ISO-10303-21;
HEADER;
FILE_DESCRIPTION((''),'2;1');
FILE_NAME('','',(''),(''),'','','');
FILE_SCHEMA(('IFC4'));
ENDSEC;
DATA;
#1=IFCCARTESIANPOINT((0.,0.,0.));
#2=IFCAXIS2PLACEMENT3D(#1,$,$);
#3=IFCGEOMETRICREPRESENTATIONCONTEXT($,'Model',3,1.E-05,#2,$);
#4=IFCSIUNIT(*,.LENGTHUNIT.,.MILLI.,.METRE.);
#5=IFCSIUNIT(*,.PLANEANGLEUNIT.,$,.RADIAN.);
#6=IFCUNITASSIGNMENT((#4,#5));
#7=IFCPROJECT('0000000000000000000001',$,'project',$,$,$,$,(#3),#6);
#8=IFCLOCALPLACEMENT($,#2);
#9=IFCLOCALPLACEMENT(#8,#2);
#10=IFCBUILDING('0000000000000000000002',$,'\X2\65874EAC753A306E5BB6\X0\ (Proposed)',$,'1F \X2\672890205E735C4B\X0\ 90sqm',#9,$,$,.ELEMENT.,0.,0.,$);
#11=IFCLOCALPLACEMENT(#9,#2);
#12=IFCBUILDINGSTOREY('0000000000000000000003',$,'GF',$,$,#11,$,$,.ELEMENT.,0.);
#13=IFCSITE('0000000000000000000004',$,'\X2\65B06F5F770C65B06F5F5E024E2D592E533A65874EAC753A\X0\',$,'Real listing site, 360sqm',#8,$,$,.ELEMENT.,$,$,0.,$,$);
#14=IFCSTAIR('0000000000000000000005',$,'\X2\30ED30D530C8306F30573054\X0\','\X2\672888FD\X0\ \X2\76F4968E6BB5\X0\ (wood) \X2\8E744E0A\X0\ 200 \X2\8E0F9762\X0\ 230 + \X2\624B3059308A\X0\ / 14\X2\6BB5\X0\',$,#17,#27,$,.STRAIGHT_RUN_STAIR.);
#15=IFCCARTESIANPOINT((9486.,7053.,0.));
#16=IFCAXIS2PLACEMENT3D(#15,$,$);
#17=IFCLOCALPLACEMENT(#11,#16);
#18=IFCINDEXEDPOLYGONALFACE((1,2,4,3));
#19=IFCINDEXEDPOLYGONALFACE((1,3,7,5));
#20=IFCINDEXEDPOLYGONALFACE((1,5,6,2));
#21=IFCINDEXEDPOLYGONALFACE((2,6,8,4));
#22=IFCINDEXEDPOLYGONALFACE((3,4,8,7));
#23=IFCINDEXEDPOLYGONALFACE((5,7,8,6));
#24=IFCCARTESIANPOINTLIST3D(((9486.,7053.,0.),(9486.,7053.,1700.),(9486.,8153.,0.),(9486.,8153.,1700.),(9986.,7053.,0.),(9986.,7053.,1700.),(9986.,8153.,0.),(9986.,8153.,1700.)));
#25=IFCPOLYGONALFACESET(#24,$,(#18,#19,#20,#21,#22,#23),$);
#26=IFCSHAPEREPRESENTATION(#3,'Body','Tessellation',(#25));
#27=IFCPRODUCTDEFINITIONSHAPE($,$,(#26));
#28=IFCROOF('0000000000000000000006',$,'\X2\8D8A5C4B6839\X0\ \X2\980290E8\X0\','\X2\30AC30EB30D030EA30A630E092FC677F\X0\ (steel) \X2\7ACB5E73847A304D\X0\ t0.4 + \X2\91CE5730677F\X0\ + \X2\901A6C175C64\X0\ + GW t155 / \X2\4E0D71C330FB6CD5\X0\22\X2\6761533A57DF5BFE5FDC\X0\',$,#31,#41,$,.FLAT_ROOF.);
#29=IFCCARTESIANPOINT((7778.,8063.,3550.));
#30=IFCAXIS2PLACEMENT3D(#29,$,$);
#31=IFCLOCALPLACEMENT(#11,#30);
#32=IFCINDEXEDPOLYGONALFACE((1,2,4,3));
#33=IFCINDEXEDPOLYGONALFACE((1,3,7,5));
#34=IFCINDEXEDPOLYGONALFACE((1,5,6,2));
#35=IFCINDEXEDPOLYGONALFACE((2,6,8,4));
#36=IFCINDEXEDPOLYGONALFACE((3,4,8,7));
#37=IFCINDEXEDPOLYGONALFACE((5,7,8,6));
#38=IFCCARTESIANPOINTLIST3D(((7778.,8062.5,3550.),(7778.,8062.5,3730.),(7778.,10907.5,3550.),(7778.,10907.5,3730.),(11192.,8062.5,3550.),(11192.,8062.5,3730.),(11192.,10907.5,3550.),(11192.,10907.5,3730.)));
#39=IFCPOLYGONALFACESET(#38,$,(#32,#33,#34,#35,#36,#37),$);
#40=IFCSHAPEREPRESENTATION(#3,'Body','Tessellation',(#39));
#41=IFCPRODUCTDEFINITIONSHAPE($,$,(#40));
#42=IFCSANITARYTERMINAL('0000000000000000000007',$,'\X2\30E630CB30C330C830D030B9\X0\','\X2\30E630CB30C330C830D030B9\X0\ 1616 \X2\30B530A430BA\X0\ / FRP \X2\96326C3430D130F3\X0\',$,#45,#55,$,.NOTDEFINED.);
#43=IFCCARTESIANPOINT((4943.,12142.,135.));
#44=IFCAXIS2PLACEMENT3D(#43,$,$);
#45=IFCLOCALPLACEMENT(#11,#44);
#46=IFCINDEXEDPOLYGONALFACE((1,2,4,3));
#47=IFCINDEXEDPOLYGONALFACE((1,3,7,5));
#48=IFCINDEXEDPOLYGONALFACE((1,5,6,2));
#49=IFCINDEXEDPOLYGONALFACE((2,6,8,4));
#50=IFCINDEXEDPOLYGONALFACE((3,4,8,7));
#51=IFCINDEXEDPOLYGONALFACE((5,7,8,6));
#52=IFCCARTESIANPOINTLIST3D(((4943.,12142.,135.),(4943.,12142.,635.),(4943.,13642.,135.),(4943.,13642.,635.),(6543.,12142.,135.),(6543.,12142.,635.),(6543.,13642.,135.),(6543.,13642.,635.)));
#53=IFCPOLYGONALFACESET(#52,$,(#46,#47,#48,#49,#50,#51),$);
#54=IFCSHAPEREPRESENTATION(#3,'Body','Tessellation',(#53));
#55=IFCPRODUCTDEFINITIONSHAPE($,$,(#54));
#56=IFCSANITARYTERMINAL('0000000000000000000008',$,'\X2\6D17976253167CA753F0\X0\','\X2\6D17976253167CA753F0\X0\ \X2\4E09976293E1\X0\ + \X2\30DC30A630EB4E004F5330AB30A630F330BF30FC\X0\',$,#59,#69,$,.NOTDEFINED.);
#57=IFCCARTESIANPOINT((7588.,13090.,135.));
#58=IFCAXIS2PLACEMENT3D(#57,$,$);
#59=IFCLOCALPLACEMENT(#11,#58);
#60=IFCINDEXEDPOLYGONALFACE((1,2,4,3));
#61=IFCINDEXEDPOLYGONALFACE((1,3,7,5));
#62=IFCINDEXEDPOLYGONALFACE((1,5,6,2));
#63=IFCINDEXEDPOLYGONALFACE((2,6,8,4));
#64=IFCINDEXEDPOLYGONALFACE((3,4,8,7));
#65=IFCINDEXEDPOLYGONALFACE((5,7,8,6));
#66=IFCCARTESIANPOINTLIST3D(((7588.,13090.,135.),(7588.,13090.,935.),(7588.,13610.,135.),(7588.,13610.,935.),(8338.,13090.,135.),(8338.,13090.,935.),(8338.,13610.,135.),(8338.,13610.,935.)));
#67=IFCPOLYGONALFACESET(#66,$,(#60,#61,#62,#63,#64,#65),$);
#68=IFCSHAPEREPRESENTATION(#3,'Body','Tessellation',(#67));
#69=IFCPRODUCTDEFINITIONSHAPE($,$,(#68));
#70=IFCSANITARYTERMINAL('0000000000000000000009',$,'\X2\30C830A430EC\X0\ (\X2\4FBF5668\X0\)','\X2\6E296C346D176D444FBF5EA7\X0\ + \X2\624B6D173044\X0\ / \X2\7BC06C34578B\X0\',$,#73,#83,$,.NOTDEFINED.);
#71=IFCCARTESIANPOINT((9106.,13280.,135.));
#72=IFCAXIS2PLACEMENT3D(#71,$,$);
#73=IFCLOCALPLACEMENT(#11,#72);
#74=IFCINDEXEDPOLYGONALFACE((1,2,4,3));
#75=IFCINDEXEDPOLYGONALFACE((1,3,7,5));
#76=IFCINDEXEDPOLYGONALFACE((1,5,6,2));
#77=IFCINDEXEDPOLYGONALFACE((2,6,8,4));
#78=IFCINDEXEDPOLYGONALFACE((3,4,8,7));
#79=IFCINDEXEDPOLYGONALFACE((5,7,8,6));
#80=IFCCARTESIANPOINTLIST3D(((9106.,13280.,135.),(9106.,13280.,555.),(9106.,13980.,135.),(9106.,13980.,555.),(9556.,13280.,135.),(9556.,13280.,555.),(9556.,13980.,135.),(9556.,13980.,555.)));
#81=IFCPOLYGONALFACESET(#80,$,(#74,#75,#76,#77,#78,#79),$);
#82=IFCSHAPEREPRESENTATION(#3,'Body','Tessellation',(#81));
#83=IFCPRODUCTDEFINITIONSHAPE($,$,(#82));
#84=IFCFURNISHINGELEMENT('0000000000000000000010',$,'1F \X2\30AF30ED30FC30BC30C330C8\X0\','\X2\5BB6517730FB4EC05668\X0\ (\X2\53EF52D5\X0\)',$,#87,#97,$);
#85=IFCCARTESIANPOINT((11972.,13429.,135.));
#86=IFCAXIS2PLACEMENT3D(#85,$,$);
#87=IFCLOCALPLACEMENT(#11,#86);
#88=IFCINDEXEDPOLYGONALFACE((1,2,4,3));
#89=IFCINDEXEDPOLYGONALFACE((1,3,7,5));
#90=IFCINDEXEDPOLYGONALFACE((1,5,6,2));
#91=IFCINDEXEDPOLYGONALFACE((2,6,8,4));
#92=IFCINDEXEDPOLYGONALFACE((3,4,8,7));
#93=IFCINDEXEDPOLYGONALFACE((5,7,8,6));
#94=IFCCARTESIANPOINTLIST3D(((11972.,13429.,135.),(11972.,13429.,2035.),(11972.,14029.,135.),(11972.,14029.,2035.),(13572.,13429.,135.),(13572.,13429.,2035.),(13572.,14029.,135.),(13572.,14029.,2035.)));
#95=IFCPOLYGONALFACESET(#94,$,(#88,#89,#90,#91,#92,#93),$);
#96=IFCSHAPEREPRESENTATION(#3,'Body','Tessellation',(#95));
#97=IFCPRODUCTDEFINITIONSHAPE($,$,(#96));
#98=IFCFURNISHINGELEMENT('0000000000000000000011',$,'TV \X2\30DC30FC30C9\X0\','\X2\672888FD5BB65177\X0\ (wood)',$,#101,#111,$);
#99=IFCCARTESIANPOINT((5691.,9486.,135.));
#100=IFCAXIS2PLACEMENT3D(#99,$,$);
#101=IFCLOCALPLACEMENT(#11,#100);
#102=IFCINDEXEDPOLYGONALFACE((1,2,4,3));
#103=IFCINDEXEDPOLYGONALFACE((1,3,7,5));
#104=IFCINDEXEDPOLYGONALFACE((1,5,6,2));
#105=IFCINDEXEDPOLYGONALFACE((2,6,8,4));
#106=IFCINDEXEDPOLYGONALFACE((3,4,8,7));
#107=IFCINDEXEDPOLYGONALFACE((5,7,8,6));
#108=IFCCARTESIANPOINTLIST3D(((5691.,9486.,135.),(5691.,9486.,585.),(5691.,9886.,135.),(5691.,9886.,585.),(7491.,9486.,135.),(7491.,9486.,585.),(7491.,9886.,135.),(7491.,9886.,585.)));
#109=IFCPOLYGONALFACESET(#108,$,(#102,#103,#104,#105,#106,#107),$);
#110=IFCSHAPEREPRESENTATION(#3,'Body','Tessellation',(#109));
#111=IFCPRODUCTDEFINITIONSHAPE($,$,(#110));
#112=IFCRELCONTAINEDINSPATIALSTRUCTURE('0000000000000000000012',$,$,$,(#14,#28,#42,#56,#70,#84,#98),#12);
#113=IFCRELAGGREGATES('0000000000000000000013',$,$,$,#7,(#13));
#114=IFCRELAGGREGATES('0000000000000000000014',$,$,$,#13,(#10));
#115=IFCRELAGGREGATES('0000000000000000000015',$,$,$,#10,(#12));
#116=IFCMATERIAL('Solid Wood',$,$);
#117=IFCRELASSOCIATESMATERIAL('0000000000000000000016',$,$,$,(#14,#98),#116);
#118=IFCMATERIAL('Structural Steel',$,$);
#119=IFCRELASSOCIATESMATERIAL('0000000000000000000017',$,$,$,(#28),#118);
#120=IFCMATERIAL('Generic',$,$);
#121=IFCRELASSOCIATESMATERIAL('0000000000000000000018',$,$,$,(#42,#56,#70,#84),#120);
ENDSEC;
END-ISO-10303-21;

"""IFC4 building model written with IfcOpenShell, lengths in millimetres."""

from ifc_helpers import new_model, si_unit, frame, frame_2d, origin, place, context, project, spatial, rectangle, extrude, material, element, save


model = new_model("IFC4")

# Units and contexts
model_context = context("Model", 3, precision=1e-05, world=origin())
ifc_project = project(units=[si_unit("LENGTHUNIT", "METRE", prefix="MILLI"), si_unit("PLANEANGLEUNIT", "RADIAN")], contexts=[model_context])

# Site, building, storey
site_placement = place(None, origin())
site = spatial("IfcSite", under=ifc_project, at=site_placement, Name="新潟県新潟市中央区文京町", ObjectType="Real listing site, 360sqm", CompositionType="ELEMENT", RefElevation=0.0)
building_placement = place(site_placement, origin())
building = spatial("IfcBuilding", under=site, at=building_placement, Name="文京町の家 (Proposed)", ObjectType="1F 木造平屋 90sqm", CompositionType="ELEMENT", ElevationOfRefHeight=0.0, ElevationOfTerrain=0.0)
storey_placement = place(building_placement, origin())
storey = spatial("IfcBuildingStorey", under=building, at=storey_placement, Name="GF", CompositionType="ELEMENT", Elevation=0.0)

# Shared definitions
ifc_material_1 = material(Name="Solid Wood")

# Stair
stair_placement = place(storey_placement, frame((9486.0, 7053.0, 0.0)))
element("IfcStair", 1, at=stair_placement, inside=storey, material=ifc_material_1, Name="ロフトはしご", Description="木製 直階段 (wood) 蹴上 200 踏面 230 + 手すり / 14段", PredefinedType="STRAIGHT_RUN_STAIR", context=model_context, shape_type="SweptSolid", body=[
    extrude(rectangle(XDim=500.0, YDim=1100.0, at=frame_2d((250.0, 550.0))), frame((9486.0, 7053.0, 0.0)), (0.0, 0.0, 1.0), 1700.0),
])

# Roof
ifc_material_2 = material(Name="Structural Steel")
roof_placement = place(storey_placement, frame((7778.0, 8063.0, 3550.0)))
element("IfcRoof", 2, at=roof_placement, inside=storey, material=ifc_material_2, Name="越屋根 頂部", Description="ガルバリウム鋼板 (steel) 立平葺き t0.4 + 野地板 + 通気層 + GW t155 / 不燃・法22条区域対応", PredefinedType="FLAT_ROOF", context=model_context, shape_type="SweptSolid", body=[
    extrude(rectangle(XDim=3414.0, YDim=2845.0, at=frame_2d((1707.0, 1422.0))), frame((7778.0, 8063.0, 3550.0)), (0.0, 0.0, 1.0), 180.0),
])

# Sanitary terminals
ifc_material_3 = material(Name="Generic")
sanitary_terminal_1_placement = place(storey_placement, frame((4943.0, 12142.0, 135.0)))
element("IfcSanitaryTerminal", 3, at=sanitary_terminal_1_placement, inside=storey, material=ifc_material_3, Name="ユニットバス", Description="ユニットバス 1616 サイズ / FRP 防水パン", PredefinedType="NOTDEFINED", context=model_context, shape_type="SweptSolid", body=[
    extrude(rectangle(XDim=1600.0, YDim=1500.0, at=frame_2d((800.0, 750.0))), frame((4943.0, 12142.0, 135.0)), (0.0, 0.0, 1.0), 500.0),
])
sanitary_terminal_2_placement = place(storey_placement, frame((7588.0, 13090.0, 135.0)))
element("IfcSanitaryTerminal", 4, at=sanitary_terminal_2_placement, inside=storey, material=ifc_material_3, Name="洗面化粧台", Description="洗面化粧台 三面鏡 + ボウル一体カウンター", PredefinedType="NOTDEFINED", context=model_context, shape_type="SweptSolid", body=[
    extrude(rectangle(XDim=750.0, YDim=520.0, at=frame_2d((375.0, 260.0))), frame((7588.0, 13090.0, 135.0)), (0.0, 0.0, 1.0), 800.0),
])
sanitary_terminal_3_placement = place(storey_placement, frame((9106.0, 13280.0, 135.0)))
element("IfcSanitaryTerminal", 5, at=sanitary_terminal_3_placement, inside=storey, material=ifc_material_3, Name="トイレ (便器)", Description="温水洗浄便座 + 手洗い / 節水型", PredefinedType="NOTDEFINED", context=model_context, shape_type="SweptSolid", body=[
    extrude(rectangle(XDim=450.0, YDim=700.0, at=frame_2d((225.0, 350.0))), frame((9106.0, 13280.0, 135.0)), (0.0, 0.0, 1.0), 420.0),
])

# Furnishing elements
furnishing_1_placement = place(storey_placement, frame((11972.0, 13429.0, 135.0)))
element("IfcFurnishingElement", 6, at=furnishing_1_placement, inside=storey, material=ifc_material_3, Name="1F クローゼット", Description="家具・什器 (可動)", context=model_context, shape_type="SweptSolid", body=[
    extrude(rectangle(XDim=1600.0, YDim=600.0, at=frame_2d((800.0, 300.0))), frame((11972.0, 13429.0, 135.0)), (0.0, 0.0, 1.0), 1900.0),
])
furnishing_2_placement = place(storey_placement, frame((5691.0, 9486.0, 135.0)))
element("IfcFurnishingElement", 7, at=furnishing_2_placement, inside=storey, material=ifc_material_1, Name="TV ボード", Description="木製家具 (wood)", context=model_context, shape_type="SweptSolid", body=[
    extrude(rectangle(XDim=1800.0, YDim=400.0, at=frame_2d((900.0, 200.0))), frame((5691.0, 9486.0, 135.0)), (0.0, 0.0, 1.0), 450.0),
])

save(model, "model.ifc")
